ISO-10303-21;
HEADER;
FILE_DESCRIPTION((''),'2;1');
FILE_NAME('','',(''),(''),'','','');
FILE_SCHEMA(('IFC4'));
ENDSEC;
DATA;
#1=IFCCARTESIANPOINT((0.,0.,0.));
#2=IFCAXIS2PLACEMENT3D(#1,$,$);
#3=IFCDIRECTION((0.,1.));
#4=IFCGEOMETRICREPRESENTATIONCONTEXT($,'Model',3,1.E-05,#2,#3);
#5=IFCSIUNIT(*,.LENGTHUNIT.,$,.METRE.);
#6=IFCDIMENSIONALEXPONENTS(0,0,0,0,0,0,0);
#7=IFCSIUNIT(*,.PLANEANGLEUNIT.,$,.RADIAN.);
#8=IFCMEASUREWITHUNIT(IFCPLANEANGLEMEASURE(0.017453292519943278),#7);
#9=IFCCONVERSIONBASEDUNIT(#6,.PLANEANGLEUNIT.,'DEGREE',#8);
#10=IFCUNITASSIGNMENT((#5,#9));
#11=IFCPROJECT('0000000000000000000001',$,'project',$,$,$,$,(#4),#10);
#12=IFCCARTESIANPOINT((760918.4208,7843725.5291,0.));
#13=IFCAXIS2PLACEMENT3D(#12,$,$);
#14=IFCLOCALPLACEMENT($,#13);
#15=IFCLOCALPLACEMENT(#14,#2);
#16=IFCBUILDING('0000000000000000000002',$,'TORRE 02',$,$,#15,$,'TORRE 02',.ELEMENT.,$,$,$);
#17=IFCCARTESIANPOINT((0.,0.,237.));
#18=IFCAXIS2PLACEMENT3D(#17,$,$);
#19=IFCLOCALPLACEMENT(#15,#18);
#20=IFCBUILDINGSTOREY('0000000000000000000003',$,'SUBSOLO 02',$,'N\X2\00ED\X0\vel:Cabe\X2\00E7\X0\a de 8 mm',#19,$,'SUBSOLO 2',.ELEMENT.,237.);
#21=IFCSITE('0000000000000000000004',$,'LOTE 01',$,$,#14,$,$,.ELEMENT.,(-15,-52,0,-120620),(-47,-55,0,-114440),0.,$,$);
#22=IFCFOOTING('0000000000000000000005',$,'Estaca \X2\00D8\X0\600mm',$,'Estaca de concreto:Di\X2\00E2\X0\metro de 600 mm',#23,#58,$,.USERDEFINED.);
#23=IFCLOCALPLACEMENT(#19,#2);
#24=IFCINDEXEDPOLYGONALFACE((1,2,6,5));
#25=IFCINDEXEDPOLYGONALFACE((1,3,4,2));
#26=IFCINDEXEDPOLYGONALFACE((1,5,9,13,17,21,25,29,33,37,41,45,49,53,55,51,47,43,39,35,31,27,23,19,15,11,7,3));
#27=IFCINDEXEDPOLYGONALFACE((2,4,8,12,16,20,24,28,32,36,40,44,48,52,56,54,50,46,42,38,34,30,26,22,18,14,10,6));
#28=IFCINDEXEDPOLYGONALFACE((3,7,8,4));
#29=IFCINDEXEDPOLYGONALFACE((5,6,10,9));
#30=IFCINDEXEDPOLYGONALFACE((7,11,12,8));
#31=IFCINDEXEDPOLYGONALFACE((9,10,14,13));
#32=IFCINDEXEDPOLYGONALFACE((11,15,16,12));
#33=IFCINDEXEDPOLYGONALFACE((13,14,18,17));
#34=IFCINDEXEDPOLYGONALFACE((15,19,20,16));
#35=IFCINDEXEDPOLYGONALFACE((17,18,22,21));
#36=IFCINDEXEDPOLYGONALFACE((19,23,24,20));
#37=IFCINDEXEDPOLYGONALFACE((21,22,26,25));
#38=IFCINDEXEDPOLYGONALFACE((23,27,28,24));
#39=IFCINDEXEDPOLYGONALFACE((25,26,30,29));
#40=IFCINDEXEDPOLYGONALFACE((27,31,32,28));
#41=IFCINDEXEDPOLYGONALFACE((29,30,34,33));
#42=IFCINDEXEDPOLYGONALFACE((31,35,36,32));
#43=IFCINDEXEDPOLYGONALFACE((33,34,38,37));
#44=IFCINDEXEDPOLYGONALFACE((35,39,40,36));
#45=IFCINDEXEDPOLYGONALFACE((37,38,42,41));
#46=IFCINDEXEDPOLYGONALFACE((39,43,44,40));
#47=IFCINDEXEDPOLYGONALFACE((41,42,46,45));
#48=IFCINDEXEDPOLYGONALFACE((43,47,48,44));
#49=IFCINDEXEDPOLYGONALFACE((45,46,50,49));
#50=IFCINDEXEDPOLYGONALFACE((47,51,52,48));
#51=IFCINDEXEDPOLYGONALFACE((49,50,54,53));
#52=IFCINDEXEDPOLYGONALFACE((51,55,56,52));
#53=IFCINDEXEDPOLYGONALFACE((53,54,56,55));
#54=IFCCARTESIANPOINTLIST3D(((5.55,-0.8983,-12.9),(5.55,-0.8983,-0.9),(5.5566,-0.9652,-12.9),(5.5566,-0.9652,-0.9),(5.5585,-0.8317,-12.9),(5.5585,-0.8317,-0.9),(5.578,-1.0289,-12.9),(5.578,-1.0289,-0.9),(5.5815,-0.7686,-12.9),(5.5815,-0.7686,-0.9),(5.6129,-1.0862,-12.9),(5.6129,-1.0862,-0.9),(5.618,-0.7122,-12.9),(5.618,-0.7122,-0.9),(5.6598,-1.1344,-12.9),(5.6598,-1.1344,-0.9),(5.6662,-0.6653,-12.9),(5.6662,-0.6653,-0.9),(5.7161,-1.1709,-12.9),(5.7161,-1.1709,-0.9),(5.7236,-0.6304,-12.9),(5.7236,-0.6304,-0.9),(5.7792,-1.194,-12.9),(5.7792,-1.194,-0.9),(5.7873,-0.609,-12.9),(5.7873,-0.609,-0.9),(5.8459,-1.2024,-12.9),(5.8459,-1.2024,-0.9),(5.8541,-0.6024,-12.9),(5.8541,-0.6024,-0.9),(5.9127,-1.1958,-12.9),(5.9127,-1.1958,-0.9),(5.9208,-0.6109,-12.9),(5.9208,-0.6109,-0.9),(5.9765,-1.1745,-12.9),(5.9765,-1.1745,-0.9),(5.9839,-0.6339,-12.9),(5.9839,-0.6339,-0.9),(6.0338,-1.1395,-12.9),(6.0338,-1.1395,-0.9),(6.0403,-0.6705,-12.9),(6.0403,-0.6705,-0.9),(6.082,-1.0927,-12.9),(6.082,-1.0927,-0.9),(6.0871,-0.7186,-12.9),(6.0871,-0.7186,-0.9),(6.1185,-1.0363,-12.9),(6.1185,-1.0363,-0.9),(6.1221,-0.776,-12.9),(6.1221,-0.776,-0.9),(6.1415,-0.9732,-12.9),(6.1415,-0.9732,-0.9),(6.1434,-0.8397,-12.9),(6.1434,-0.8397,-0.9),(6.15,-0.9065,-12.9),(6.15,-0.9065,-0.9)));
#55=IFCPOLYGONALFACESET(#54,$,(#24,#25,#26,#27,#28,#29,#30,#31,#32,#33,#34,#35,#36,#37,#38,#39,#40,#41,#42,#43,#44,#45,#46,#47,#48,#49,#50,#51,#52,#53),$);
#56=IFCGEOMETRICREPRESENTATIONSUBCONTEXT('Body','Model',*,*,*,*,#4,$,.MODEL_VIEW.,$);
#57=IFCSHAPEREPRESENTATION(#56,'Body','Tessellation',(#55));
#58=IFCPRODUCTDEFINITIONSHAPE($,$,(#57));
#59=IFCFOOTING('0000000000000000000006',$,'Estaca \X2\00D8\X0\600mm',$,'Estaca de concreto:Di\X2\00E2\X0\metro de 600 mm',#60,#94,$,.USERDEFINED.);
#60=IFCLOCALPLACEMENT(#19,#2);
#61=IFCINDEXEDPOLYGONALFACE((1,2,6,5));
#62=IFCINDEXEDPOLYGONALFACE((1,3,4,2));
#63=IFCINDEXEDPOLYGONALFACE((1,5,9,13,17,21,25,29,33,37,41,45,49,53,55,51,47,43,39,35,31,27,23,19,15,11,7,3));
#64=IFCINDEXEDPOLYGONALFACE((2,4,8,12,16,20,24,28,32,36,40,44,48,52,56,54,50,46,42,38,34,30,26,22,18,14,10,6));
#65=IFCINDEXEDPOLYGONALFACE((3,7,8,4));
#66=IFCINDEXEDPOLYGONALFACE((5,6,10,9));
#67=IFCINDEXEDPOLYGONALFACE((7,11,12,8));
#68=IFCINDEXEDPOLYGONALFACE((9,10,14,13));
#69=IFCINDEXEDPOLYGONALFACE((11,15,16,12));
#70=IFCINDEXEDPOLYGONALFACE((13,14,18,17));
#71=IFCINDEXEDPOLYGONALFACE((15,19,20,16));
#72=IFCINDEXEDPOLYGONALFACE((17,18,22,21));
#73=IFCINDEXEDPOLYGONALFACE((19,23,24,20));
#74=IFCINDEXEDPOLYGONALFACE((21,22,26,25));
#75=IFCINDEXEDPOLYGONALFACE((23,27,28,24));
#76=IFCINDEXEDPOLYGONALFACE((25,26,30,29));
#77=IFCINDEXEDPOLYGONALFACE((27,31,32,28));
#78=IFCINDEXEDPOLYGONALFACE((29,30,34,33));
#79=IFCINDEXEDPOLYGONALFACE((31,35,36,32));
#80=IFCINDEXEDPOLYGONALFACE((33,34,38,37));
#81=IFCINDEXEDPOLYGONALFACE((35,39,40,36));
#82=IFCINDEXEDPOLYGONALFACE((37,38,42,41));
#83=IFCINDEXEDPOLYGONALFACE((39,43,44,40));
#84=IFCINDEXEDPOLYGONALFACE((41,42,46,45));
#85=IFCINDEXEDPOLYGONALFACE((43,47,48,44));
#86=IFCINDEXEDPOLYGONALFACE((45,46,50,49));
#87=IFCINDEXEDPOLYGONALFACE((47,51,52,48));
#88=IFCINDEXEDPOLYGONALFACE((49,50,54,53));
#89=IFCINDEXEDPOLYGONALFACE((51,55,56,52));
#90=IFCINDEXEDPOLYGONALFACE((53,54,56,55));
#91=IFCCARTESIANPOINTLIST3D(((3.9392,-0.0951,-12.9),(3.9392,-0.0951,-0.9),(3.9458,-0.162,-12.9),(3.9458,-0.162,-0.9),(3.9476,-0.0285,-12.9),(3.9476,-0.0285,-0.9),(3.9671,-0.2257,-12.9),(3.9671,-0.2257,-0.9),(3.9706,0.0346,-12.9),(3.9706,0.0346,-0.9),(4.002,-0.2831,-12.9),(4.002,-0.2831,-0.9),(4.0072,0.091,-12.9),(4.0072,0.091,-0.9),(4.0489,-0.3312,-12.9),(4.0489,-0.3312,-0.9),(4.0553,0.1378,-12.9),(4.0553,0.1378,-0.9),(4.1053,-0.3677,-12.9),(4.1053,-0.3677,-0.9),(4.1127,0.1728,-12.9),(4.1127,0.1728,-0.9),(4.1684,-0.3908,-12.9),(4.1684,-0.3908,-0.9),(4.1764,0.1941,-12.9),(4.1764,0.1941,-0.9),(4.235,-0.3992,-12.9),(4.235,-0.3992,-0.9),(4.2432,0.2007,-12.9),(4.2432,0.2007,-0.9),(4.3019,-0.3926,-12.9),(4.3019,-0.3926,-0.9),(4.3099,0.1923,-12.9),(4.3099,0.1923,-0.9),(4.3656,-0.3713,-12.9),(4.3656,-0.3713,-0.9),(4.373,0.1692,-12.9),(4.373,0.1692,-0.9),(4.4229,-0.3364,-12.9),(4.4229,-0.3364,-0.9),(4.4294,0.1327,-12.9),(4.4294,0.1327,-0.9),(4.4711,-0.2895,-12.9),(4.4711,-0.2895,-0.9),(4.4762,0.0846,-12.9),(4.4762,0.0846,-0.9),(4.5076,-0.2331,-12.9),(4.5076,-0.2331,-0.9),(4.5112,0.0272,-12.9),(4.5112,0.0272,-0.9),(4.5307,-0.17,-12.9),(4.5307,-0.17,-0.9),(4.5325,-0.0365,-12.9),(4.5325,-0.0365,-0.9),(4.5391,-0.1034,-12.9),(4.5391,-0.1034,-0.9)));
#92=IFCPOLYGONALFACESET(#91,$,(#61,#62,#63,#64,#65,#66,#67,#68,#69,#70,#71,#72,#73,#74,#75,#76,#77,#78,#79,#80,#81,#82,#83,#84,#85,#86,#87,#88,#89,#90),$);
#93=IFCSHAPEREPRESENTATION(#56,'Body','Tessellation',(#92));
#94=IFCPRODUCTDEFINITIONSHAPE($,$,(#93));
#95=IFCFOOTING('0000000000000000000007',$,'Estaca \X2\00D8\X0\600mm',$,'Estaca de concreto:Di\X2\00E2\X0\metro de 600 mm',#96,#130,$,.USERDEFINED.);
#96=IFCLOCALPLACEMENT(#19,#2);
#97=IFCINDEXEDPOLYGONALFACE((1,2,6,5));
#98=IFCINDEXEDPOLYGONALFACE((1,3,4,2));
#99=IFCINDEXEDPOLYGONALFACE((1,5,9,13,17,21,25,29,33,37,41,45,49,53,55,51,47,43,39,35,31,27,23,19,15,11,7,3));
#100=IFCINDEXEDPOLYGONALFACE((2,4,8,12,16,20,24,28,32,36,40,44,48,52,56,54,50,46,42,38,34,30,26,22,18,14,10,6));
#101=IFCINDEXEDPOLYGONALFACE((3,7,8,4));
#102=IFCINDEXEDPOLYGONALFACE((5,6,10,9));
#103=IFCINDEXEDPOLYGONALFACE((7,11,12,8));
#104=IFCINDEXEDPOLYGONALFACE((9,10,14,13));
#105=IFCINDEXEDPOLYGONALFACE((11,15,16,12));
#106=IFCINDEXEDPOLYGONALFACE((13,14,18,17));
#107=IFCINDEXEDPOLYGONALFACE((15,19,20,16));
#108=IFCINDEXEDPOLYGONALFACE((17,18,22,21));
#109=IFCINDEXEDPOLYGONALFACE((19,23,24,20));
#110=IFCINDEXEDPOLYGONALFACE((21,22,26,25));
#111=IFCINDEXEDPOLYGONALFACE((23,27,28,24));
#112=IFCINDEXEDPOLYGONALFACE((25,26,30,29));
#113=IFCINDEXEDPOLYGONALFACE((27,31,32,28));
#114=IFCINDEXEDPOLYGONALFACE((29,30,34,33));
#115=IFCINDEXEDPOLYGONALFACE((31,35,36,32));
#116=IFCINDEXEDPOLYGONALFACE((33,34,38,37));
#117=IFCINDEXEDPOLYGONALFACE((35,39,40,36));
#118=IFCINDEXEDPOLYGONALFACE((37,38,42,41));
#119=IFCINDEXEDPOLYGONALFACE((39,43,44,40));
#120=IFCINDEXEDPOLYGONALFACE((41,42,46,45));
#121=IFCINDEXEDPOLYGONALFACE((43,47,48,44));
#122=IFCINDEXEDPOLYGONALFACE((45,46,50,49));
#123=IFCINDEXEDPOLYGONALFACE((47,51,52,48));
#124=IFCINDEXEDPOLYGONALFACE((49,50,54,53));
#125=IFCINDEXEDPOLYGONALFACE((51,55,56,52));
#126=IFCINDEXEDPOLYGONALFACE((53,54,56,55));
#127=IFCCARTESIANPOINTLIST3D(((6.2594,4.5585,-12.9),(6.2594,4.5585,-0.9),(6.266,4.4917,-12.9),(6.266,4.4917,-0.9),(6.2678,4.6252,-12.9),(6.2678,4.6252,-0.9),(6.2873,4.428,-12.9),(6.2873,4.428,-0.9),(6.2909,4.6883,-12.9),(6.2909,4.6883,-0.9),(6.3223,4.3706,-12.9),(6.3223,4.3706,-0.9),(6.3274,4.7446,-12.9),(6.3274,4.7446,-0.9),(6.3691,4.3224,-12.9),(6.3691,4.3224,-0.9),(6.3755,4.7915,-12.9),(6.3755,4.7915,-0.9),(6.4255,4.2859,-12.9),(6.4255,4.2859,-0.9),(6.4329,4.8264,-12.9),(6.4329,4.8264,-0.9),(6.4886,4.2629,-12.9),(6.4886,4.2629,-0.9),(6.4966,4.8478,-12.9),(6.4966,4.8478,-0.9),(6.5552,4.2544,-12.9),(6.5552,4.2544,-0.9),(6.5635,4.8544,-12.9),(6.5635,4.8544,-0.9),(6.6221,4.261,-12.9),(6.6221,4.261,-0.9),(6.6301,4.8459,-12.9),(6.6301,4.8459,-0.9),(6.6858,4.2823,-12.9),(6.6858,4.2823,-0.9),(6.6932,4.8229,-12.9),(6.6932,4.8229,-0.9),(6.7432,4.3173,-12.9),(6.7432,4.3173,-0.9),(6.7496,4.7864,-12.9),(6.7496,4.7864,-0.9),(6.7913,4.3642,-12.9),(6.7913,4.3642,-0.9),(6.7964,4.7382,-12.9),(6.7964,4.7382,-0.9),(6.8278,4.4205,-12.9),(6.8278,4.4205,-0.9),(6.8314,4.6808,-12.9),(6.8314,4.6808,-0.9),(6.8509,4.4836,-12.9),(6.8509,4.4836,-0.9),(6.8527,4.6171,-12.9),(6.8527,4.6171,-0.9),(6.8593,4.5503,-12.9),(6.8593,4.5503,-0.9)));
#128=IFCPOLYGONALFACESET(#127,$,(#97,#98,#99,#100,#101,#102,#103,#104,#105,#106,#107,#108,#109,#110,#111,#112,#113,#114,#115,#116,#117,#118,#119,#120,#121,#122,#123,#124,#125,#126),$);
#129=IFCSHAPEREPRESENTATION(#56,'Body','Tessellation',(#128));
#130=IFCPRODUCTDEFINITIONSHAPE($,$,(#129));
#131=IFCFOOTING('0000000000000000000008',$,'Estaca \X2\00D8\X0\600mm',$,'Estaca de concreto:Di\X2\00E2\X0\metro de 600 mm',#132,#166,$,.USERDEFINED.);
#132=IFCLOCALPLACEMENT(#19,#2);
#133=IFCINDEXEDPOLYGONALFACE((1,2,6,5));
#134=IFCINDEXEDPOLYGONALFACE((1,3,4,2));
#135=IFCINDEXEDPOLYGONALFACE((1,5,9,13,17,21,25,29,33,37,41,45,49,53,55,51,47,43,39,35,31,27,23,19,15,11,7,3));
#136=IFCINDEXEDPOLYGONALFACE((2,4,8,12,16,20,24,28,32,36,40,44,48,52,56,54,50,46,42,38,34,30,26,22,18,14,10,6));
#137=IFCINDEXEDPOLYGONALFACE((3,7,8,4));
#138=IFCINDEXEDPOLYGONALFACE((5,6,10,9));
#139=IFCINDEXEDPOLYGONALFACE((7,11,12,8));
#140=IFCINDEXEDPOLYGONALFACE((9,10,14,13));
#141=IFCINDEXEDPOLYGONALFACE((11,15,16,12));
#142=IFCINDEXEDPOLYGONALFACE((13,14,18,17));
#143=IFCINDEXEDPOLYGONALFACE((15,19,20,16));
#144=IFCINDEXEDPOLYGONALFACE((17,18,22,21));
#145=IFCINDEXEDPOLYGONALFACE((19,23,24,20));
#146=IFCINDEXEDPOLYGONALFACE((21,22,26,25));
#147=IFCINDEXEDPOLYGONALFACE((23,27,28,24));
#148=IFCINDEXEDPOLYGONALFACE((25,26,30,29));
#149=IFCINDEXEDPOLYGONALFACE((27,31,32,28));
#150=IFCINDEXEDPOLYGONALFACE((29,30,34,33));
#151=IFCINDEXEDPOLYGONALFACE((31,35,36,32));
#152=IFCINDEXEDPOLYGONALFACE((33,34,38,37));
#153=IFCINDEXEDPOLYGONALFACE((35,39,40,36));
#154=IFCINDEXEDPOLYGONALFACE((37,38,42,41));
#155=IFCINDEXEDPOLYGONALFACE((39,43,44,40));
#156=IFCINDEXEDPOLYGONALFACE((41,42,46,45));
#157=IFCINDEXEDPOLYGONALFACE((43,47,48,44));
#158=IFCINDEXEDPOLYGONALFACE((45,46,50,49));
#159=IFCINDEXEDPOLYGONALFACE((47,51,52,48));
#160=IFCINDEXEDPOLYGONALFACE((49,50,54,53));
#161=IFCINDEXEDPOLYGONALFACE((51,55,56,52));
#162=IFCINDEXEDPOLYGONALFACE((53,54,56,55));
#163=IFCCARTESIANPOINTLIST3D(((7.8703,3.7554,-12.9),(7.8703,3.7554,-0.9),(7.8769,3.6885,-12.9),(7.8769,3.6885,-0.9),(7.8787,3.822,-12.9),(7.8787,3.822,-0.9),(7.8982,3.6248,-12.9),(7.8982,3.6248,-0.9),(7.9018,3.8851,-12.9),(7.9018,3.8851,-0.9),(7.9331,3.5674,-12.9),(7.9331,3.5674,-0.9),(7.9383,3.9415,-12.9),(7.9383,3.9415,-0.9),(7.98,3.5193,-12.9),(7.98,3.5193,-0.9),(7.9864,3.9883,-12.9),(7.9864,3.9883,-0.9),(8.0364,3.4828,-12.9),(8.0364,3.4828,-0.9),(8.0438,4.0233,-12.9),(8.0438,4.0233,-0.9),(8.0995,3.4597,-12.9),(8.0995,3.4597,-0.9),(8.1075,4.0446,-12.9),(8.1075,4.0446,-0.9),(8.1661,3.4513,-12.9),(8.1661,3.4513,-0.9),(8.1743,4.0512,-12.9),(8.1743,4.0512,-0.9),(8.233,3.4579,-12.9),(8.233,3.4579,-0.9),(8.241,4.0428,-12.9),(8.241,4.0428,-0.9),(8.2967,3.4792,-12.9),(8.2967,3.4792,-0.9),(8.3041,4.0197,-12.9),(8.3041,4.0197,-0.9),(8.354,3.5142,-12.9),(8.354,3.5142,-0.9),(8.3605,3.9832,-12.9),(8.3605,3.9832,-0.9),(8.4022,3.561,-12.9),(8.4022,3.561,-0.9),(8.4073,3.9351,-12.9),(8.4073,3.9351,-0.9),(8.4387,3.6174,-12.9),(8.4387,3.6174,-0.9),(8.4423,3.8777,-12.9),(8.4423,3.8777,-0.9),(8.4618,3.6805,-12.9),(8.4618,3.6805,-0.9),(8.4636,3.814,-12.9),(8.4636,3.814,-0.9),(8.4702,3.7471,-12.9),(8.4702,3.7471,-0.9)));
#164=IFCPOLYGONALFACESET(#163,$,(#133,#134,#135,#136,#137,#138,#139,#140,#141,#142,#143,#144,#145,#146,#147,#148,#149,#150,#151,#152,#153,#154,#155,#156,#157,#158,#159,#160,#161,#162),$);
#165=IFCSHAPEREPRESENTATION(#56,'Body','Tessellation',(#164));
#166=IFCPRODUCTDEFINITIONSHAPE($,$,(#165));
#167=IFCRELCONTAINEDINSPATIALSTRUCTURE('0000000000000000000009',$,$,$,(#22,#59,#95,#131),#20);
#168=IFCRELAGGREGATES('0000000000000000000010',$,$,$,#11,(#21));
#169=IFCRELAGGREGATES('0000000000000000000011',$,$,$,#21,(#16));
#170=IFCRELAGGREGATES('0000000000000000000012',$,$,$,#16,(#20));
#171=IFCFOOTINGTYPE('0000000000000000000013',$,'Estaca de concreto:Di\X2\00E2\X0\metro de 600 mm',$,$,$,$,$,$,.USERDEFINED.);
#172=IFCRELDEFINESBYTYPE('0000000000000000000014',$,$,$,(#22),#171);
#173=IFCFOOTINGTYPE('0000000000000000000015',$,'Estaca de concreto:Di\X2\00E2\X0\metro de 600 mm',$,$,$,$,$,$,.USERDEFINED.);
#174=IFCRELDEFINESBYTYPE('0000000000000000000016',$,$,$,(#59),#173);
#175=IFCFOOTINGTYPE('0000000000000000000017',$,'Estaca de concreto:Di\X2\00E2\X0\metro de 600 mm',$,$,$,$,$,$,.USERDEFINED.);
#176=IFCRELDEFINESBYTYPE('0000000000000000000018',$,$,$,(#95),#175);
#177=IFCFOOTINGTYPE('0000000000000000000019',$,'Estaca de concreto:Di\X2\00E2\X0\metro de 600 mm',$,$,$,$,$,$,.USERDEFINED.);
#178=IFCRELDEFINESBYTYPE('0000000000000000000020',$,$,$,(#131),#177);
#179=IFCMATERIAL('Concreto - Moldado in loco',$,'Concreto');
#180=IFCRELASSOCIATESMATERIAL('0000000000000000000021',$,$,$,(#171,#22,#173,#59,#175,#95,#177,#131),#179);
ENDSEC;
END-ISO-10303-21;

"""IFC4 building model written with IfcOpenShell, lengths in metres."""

from ifc_helpers import new_model, entity, si_unit, converted_unit, direction, frame, origin, place, context, subcontext, project, spatial, arc, indexed_curve, outline, extrude, source, transform, mapped, material, type_object, type_shapes, element, save


model = new_model("IFC4")

# Units and contexts
model_context = context("Model", 3, precision=1e-05, world=origin(), true_north=direction((0.0, 1.0)))
body_context = subcontext(model_context, "Body", "Model", "MODEL_VIEW")
ifc_project = project(units=[si_unit("LENGTHUNIT", "METRE"), converted_unit("PLANEANGLEUNIT", "DEGREE", entity("IfcPlaneAngleMeasure", 0.017453292519943278), si_unit("PLANEANGLEUNIT", "RADIAN"), dimensions=[0, 0, 0, 0, 0, 0, 0])], contexts=[model_context])

# Site, building, storey
site_placement = place(None, frame((760918.4208, 7843725.5291, 0.0)))
site = spatial("IfcSite", under=ifc_project, at=site_placement, Name="LOTE 01", CompositionType="ELEMENT", RefLatitude=(-15, -52, 0, -120620), RefLongitude=(-47, -55, 0, -114440), RefElevation=0.0)
building_placement = place(site_placement, origin())
building = spatial("IfcBuilding", under=site, at=building_placement, Name="TORRE 02", LongName="TORRE 02", CompositionType="ELEMENT")
storey_placement = place(building_placement, frame((0.0, 0.0, 237.0)))
storey = spatial("IfcBuildingStorey", under=building, at=storey_placement, Name="SUBSOLO 02", ObjectType="Nível:Cabeça de 8 mm", LongName="SUBSOLO 2", CompositionType="ELEMENT", Elevation=237.0)

# Footings
ifc_material = material(Name="Concreto - Moldado in loco", Category="Concreto")
placement = place(building_placement, frame((0.0, 0.0, 237.0)))
footing_type_1 = type_object("IfcFootingType", Name="Estaca de concreto:Diâmetro de 600 mm", PredefinedType="USERDEFINED", material=ifc_material)
shared_shape_1 = source(origin(), body_context, "Body", "SweptSolid", [
    extrude(outline(indexed_curve([(-0.3, 0.0), (0.0, -0.3), (0.3, 0.0), (0.0, 0.3)], segments=[arc(1, 2, 3), arc(3, 4, 1)], self_intersect=False)), frame((5.85, -0.9024, -12.0), z_axis=(0.0, 0.0, 1.0), x_axis=(0.894934, -0.446198, 0.0)), (0.0, 0.0, 1.0), 12.0),
])
type_shapes(footing_type_1, [shared_shape_1])
footing_1_placement = place(placement, frame((0.0, 0.0, -0.9)))
element("IfcFooting", 1, at=footing_1_placement, inside=storey, type_object=footing_type_1, material=ifc_material, Name="Estaca Ø600mm", ObjectType="Estaca de concreto:Diâmetro de 600 mm", PredefinedType="USERDEFINED", context=body_context, shape_type="MappedRepresentation", body=[
    mapped(shared_shape_1, transform((0.0, 0.0, 0.0), scale=1.0)),
])
footing_type_2 = type_object("IfcFootingType", Name="Estaca de concreto:Diâmetro de 600 mm", PredefinedType="USERDEFINED", material=ifc_material)
shared_shape_2 = source(origin(), body_context, "Body", "SweptSolid", [
    extrude(outline(indexed_curve([(-0.3, 0.0), (0.0, -0.3), (0.3, 0.0), (0.0, 0.3)], segments=[arc(1, 2, 3), arc(3, 4, 1)], self_intersect=False)), frame((4.2391, -0.0993, -12.0), z_axis=(0.0, 0.0, 1.0), x_axis=(0.894934, -0.446198, 0.0)), (0.0, 0.0, 1.0), 12.0),
])
type_shapes(footing_type_2, [shared_shape_2])
footing_2_placement = place(placement, frame((0.0, 0.0, -0.9)))
element("IfcFooting", 2, at=footing_2_placement, inside=storey, type_object=footing_type_2, material=ifc_material, Name="Estaca Ø600mm", ObjectType="Estaca de concreto:Diâmetro de 600 mm", PredefinedType="USERDEFINED", context=body_context, shape_type="MappedRepresentation", body=[
    mapped(shared_shape_2, transform((0.0, 0.0, 0.0), scale=1.0)),
])
footing_type_3 = type_object("IfcFootingType", Name="Estaca de concreto:Diâmetro de 600 mm", PredefinedType="USERDEFINED", material=ifc_material)
shared_shape_3 = source(origin(), body_context, "Body", "SweptSolid", [
    extrude(outline(indexed_curve([(-0.3, 0.0), (0.0, -0.3), (0.3, 0.0), (0.0, 0.3)], segments=[arc(1, 2, 3), arc(3, 4, 1)], self_intersect=False)), frame((6.5594, 4.5544, -12.0), z_axis=(0.0, 0.0, 1.0), x_axis=(0.894934, -0.446198, 0.0)), (0.0, 0.0, 1.0), 12.0),
])
type_shapes(footing_type_3, [shared_shape_3])
footing_3_placement = place(placement, frame((0.0, 0.0, -0.9)))
element("IfcFooting", 3, at=footing_3_placement, inside=storey, type_object=footing_type_3, material=ifc_material, Name="Estaca Ø600mm", ObjectType="Estaca de concreto:Diâmetro de 600 mm", PredefinedType="USERDEFINED", context=body_context, shape_type="MappedRepresentation", body=[
    mapped(shared_shape_3, transform((0.0, 0.0, 0.0), scale=1.0)),
])
footing_type_4 = type_object("IfcFootingType", Name="Estaca de concreto:Diâmetro de 600 mm", PredefinedType="USERDEFINED", material=ifc_material)
shared_shape_4 = source(origin(), body_context, "Body", "SweptSolid", [
    extrude(outline(indexed_curve([(-0.3, 0.0), (0.0, -0.3), (0.3, 0.0), (0.0, 0.3)], segments=[arc(1, 2, 3), arc(3, 4, 1)], self_intersect=False)), frame((8.1702, 3.7512, -12.0), z_axis=(0.0, 0.0, 1.0), x_axis=(0.894934, -0.446198, 0.0)), (0.0, 0.0, 1.0), 12.0),
])
type_shapes(footing_type_4, [shared_shape_4])
footing_4_placement = place(placement, frame((0.0, 0.0, -0.9)))
element("IfcFooting", 4, at=footing_4_placement, inside=storey, type_object=footing_type_4, material=ifc_material, Name="Estaca Ø600mm", ObjectType="Estaca de concreto:Diâmetro de 600 mm", PredefinedType="USERDEFINED", context=body_context, shape_type="MappedRepresentation", body=[
    mapped(shared_shape_4, transform((0.0, 0.0, 0.0), scale=1.0)),
])

save(model, "model.ifc")
